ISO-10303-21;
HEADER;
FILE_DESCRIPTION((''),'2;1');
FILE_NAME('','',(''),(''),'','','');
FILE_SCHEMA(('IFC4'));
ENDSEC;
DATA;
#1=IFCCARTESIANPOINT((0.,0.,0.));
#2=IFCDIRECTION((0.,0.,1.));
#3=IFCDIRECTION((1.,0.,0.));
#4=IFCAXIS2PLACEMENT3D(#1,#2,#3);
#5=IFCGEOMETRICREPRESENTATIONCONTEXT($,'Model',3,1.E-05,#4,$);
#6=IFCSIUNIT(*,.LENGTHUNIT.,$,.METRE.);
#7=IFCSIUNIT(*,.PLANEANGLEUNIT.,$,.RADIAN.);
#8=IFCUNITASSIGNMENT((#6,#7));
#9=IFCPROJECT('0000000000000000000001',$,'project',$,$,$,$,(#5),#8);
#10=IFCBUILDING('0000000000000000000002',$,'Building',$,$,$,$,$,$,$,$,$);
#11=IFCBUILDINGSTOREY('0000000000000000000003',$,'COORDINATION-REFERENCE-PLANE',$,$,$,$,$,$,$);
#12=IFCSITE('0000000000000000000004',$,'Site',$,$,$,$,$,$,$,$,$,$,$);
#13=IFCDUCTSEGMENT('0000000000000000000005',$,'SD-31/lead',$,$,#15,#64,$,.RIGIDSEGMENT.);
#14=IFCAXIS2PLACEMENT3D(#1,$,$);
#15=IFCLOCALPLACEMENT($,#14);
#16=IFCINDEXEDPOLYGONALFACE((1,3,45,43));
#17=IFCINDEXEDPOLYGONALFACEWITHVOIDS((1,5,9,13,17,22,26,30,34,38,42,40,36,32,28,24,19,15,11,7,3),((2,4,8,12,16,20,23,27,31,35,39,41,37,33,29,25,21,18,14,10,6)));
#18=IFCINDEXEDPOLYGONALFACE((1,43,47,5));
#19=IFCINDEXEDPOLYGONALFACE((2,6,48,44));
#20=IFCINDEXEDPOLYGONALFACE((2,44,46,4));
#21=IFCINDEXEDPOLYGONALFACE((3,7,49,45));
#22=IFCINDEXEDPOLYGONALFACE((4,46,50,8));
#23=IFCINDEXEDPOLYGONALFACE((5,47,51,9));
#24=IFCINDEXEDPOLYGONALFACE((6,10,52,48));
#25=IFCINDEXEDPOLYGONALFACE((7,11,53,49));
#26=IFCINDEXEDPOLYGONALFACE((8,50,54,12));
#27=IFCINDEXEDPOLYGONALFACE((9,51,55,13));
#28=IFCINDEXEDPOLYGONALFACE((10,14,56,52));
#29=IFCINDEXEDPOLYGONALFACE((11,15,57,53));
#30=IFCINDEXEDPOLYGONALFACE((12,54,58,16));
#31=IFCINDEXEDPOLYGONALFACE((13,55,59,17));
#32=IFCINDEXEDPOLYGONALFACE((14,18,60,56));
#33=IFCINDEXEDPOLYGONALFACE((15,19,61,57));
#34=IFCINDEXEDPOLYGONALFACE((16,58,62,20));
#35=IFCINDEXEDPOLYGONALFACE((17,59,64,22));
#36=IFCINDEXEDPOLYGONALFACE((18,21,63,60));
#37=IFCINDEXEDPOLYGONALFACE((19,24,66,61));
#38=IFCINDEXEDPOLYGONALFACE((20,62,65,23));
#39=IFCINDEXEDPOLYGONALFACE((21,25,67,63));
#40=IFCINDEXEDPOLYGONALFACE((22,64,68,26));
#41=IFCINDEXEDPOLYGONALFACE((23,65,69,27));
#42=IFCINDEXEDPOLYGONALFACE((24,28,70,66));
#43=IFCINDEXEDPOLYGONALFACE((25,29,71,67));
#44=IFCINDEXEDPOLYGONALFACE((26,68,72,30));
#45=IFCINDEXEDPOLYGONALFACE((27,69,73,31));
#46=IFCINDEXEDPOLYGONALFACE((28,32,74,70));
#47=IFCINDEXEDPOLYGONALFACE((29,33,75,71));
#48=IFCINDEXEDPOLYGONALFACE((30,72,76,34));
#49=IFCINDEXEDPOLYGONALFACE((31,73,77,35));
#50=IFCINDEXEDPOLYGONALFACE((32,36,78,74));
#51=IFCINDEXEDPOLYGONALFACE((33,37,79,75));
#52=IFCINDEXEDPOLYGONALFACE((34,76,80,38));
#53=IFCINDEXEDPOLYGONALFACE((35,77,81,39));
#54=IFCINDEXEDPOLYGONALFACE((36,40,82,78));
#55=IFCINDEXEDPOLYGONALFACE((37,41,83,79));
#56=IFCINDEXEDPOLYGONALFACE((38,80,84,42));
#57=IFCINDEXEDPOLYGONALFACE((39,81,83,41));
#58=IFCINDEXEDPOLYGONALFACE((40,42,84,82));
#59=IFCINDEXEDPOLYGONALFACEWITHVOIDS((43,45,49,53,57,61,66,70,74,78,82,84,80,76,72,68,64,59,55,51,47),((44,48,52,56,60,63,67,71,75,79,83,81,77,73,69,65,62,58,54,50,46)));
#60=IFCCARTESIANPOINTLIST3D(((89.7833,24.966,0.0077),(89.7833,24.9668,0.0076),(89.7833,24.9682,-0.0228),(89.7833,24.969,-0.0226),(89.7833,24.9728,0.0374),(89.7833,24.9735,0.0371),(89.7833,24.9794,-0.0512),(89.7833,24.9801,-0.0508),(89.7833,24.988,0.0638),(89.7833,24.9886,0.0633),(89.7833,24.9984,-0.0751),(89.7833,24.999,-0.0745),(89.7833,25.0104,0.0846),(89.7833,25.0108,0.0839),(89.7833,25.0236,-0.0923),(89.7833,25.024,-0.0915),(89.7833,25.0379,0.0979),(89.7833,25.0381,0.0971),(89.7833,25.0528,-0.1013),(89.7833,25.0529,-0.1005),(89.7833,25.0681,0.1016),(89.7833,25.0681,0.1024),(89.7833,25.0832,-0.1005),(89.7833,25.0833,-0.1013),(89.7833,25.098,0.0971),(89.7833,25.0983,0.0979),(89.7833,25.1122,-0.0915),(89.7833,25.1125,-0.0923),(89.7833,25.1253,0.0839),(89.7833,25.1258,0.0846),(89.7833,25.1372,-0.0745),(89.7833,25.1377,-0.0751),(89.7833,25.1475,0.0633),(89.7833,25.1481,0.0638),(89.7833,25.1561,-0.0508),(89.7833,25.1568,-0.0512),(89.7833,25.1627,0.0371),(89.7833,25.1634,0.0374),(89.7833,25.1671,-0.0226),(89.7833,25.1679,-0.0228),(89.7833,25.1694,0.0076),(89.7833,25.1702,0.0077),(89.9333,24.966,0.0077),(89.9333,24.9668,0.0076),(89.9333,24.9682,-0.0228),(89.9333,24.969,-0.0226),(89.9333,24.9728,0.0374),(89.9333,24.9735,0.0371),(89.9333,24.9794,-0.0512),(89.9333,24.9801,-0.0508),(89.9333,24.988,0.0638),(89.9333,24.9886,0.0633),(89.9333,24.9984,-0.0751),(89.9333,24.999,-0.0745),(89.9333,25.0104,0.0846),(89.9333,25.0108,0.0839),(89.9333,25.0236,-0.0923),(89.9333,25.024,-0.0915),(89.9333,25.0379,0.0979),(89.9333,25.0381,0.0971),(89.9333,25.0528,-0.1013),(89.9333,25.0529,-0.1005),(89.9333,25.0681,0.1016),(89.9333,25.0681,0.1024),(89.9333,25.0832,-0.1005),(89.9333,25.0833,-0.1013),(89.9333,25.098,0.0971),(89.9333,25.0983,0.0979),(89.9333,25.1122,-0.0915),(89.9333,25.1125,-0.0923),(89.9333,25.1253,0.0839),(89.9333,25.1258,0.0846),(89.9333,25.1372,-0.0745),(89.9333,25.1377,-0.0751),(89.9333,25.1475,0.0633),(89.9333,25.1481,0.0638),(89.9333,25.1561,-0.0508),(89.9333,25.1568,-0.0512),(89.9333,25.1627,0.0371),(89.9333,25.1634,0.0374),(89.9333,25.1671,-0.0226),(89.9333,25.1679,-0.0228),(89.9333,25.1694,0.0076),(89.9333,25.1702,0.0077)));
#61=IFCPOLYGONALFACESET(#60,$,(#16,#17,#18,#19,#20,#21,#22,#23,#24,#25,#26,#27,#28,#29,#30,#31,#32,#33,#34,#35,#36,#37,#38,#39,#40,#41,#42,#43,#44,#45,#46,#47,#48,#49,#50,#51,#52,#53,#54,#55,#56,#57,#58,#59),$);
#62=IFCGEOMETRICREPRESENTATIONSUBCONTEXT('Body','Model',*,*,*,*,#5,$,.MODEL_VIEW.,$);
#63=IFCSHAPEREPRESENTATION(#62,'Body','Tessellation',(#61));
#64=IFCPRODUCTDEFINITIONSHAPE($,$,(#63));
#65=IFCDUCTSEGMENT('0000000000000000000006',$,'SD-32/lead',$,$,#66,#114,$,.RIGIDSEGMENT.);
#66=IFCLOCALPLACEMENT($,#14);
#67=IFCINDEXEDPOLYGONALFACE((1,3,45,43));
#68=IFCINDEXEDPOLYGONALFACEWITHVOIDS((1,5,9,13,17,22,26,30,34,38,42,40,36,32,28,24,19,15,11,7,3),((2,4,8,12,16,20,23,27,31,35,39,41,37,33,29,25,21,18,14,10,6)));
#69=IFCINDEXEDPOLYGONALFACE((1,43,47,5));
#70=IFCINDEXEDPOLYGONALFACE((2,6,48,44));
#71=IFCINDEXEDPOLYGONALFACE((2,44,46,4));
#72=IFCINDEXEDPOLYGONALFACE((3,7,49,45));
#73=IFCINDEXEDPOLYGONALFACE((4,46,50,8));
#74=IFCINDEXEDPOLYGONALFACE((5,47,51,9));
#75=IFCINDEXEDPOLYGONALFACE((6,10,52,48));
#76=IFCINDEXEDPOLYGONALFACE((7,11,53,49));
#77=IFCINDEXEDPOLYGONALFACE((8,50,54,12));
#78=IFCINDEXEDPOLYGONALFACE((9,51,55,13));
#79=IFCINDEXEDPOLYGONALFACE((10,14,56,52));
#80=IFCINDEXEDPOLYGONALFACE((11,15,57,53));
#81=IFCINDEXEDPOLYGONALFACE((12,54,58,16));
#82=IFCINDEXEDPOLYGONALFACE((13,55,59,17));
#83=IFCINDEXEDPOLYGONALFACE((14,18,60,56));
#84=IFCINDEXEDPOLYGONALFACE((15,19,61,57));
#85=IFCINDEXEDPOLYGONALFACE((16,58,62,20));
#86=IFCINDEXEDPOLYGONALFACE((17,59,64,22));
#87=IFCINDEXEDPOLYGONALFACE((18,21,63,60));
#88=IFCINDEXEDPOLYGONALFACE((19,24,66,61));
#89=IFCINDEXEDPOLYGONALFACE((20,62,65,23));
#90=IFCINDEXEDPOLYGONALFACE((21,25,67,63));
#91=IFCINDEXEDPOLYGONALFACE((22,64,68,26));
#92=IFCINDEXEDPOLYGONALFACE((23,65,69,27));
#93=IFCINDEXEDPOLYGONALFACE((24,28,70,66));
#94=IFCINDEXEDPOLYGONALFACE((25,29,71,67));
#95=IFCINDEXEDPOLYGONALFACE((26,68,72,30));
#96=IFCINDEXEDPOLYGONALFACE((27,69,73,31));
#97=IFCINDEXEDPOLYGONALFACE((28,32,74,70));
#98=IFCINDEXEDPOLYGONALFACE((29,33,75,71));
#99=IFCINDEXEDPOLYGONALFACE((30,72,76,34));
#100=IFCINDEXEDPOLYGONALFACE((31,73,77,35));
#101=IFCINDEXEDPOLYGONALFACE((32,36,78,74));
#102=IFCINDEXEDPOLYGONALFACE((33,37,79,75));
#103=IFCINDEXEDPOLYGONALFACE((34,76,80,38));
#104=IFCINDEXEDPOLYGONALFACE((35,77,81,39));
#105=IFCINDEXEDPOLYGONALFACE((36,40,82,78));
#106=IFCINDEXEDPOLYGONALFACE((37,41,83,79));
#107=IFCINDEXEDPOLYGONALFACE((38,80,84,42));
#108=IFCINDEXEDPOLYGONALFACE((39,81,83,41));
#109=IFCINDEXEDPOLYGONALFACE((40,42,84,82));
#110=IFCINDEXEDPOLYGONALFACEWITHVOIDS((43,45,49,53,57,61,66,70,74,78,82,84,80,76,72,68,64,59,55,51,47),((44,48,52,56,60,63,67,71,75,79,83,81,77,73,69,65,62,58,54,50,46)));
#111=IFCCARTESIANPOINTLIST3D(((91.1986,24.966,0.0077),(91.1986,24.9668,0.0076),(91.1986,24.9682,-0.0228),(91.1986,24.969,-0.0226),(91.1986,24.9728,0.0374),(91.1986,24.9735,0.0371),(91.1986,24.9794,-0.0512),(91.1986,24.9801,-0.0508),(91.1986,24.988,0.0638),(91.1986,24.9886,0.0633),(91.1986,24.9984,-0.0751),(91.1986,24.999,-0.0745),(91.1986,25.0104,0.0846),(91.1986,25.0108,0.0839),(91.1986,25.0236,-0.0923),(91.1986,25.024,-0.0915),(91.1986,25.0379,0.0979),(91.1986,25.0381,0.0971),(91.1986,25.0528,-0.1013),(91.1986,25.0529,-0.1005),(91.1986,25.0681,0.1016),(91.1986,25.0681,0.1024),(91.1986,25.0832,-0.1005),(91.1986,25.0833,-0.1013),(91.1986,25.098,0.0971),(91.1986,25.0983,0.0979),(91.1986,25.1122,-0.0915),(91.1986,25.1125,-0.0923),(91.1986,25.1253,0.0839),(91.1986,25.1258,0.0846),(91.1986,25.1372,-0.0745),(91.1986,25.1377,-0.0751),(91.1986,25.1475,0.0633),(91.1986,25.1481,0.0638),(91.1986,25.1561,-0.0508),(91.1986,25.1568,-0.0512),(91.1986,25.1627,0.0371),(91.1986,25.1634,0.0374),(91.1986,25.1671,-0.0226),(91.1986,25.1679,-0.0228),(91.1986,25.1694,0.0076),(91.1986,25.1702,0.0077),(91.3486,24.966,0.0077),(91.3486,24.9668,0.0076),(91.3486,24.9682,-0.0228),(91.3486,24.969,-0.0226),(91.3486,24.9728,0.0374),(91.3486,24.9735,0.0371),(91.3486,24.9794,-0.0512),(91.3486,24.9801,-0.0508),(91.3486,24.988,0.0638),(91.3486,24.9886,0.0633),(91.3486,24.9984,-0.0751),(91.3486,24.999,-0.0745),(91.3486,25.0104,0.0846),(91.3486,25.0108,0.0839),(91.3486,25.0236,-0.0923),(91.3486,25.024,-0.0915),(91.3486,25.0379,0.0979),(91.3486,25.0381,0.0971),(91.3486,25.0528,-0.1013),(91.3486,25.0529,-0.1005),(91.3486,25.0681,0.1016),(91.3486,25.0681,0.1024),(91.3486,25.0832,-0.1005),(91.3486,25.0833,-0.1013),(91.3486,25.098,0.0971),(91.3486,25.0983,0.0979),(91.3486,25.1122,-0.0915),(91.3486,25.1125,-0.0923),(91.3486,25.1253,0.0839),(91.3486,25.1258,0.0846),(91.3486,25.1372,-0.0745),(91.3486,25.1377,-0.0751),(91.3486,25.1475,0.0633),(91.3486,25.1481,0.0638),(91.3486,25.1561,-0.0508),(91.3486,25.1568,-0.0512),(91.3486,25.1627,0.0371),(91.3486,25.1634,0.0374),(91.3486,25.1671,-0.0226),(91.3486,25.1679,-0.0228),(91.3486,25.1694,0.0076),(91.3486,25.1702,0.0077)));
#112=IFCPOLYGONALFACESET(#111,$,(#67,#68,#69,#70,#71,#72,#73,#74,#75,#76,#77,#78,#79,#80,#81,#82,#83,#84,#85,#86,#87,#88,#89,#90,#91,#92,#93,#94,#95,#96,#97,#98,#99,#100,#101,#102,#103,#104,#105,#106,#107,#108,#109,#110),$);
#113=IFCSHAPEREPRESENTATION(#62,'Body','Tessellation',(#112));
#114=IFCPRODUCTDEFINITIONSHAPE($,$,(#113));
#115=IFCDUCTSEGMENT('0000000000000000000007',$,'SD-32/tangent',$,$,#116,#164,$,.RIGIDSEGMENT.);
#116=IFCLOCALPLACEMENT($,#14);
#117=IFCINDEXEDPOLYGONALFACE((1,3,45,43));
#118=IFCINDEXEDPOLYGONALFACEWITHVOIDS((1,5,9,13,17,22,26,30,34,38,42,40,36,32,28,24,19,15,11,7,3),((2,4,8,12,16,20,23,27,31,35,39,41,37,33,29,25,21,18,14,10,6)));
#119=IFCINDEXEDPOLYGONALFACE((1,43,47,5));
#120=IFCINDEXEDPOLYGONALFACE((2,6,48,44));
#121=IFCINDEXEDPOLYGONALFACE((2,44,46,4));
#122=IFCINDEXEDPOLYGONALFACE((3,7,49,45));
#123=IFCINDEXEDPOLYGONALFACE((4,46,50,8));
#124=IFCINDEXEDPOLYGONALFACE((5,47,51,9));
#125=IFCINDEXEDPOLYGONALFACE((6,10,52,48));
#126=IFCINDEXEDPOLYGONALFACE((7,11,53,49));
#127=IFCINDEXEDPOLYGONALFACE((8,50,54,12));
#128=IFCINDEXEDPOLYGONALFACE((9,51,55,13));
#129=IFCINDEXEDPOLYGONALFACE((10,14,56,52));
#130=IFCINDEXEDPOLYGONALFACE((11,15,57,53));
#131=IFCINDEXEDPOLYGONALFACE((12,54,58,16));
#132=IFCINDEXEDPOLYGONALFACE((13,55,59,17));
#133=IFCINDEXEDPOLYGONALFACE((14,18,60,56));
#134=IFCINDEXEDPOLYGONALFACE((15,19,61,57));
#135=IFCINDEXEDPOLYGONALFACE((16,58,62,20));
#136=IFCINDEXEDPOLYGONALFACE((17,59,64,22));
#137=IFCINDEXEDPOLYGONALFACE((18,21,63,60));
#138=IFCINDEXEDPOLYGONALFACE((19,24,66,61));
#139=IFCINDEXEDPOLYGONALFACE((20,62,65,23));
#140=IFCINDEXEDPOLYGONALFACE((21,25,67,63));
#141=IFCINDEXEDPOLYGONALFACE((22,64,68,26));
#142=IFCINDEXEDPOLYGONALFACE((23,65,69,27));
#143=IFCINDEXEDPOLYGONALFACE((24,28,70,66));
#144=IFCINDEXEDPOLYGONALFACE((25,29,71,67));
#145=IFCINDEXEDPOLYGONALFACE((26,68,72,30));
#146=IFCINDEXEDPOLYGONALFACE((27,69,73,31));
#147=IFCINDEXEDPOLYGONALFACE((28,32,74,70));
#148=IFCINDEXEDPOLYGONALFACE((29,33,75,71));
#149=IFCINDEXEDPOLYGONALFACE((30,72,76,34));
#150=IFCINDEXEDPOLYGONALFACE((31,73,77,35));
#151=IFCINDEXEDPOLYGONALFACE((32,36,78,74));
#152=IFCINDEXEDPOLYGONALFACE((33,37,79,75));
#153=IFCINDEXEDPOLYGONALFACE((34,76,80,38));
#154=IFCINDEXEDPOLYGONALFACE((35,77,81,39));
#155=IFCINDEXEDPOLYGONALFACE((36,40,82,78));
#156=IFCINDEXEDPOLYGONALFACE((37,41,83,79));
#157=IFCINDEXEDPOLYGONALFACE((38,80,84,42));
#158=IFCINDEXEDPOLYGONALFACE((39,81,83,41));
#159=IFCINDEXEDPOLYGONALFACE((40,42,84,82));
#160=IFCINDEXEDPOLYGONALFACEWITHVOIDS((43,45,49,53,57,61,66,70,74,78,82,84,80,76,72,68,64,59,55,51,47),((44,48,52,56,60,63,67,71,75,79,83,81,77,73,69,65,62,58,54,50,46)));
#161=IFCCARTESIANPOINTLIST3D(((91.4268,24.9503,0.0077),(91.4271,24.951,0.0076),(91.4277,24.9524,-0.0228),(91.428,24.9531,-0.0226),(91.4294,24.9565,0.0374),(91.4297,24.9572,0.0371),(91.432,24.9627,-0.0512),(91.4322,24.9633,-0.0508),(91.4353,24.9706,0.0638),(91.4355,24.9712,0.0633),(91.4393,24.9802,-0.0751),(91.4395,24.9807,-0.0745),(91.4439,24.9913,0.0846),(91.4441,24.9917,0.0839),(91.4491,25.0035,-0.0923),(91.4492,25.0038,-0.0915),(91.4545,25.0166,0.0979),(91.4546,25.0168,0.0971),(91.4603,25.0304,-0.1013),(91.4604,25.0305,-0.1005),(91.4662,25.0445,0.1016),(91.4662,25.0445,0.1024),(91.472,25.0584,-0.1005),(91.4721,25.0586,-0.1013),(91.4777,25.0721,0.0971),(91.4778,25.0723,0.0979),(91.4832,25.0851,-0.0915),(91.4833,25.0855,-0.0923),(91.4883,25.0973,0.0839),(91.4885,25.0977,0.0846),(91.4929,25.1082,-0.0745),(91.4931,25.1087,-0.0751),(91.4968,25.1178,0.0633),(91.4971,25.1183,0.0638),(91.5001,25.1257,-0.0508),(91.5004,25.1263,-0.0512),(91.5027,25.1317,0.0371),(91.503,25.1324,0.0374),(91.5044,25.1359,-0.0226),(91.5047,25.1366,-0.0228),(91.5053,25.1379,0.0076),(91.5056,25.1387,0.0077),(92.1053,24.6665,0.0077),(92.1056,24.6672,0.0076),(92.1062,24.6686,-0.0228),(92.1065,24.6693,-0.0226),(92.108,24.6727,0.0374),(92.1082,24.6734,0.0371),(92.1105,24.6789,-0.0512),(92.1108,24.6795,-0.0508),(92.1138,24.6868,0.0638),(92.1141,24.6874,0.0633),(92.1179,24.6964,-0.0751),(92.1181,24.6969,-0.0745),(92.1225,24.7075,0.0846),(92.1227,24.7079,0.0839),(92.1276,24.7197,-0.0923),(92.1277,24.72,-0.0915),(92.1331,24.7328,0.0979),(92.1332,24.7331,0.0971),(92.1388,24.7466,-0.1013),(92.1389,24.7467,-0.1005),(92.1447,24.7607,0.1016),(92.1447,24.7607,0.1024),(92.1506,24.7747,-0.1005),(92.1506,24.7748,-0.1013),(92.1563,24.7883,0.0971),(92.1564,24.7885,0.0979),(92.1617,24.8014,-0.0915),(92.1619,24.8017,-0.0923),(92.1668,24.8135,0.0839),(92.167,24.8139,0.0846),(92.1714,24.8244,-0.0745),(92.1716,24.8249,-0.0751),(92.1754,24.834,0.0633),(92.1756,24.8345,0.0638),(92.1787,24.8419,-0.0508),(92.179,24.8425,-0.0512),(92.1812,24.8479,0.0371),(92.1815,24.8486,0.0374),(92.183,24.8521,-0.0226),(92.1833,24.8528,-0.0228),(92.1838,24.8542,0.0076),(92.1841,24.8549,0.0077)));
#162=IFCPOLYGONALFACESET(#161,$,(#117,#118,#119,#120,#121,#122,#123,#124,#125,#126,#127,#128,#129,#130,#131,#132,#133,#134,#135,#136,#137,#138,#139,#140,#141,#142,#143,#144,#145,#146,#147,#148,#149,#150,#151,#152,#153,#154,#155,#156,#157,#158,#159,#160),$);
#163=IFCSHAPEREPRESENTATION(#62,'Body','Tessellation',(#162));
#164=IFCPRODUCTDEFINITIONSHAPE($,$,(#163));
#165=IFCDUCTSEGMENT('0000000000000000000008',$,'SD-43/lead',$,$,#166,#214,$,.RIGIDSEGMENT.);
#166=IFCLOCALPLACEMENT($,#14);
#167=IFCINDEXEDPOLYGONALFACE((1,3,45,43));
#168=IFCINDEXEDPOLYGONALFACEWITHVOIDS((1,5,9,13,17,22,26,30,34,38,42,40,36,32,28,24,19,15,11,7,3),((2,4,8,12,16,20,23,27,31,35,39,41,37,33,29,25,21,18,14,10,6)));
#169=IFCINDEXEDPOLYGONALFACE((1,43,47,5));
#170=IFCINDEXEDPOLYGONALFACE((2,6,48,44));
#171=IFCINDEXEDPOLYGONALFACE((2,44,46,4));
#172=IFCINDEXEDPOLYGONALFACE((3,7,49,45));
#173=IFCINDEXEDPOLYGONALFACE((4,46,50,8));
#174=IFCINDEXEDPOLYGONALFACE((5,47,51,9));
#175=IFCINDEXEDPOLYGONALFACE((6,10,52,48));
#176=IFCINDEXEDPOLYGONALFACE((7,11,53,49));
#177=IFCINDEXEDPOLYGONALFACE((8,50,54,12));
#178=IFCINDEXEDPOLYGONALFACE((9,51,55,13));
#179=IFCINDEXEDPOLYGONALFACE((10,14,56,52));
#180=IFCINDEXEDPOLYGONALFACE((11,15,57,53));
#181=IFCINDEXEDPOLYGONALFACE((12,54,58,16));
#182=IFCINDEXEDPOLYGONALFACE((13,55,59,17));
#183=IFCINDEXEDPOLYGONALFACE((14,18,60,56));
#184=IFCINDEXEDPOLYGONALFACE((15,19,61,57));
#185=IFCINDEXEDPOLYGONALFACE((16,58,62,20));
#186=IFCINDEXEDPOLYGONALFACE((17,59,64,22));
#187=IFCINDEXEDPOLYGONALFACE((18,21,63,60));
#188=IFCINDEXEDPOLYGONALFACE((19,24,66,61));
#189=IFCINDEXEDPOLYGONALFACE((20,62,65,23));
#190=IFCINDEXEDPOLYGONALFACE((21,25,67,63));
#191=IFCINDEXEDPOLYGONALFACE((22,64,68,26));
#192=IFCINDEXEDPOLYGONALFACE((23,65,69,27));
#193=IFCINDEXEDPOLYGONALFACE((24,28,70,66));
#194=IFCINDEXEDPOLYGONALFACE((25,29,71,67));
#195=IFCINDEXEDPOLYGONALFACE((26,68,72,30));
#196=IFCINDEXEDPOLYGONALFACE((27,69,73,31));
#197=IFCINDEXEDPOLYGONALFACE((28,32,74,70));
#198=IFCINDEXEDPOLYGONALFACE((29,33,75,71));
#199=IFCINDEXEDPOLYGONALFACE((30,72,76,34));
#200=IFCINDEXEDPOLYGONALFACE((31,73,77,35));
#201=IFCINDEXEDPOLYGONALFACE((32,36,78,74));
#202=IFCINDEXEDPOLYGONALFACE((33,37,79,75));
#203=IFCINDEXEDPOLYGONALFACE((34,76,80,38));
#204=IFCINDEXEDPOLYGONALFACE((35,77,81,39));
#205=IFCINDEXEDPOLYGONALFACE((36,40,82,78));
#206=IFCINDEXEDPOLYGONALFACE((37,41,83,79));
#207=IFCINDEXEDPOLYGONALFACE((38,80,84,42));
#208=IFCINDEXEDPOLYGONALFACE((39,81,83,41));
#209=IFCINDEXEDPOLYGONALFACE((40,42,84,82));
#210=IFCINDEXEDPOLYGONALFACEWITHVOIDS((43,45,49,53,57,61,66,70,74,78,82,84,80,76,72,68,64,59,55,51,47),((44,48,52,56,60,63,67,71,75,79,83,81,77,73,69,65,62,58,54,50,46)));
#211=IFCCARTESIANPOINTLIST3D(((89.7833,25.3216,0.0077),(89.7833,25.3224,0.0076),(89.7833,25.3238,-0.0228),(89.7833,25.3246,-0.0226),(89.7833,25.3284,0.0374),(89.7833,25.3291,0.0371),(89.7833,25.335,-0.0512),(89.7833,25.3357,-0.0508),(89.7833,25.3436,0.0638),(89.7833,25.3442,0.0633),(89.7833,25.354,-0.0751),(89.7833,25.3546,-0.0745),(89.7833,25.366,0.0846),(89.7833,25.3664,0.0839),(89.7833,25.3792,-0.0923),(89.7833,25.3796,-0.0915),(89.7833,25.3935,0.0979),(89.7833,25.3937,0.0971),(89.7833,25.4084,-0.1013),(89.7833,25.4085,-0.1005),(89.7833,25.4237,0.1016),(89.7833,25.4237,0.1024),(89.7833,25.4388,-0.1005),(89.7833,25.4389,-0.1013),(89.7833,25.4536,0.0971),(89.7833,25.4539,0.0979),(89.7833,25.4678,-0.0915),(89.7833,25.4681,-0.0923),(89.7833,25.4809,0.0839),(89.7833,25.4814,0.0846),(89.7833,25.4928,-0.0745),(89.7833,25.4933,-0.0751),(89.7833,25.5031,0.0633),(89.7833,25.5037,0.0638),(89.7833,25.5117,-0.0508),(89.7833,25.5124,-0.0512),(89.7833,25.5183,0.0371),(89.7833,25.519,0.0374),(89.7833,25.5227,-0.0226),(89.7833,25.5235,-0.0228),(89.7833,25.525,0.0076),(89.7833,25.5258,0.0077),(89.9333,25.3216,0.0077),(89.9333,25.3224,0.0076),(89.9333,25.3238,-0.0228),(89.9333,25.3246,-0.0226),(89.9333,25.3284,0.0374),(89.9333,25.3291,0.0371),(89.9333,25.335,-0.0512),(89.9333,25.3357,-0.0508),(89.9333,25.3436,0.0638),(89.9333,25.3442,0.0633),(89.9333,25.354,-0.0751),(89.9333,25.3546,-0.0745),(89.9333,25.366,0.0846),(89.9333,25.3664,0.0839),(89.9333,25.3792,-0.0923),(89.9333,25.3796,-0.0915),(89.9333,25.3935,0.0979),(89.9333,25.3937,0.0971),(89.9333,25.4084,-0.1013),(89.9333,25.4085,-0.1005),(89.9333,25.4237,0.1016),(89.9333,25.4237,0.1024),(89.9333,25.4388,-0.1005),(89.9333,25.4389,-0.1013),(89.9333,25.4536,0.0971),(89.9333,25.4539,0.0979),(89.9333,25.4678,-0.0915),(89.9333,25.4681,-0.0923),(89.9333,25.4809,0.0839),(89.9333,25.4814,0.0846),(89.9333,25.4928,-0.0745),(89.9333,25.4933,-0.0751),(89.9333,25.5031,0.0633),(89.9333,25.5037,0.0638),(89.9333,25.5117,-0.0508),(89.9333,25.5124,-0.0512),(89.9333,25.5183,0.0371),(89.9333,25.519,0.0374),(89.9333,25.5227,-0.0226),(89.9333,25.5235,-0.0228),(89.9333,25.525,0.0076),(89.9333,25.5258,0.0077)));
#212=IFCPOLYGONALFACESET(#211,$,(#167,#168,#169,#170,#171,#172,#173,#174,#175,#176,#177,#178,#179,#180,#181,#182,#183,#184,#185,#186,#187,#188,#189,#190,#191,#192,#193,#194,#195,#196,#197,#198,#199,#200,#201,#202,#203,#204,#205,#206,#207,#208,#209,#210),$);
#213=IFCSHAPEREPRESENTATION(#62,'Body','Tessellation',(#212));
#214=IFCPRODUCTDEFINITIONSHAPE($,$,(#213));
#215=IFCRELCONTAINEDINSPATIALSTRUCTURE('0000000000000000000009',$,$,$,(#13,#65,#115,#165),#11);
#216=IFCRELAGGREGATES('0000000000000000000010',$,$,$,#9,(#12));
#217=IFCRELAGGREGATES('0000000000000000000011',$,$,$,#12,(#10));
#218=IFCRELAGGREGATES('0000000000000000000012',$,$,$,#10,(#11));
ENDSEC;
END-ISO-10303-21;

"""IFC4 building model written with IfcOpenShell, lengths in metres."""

from ifc_helpers import new_model, si_unit, frame, origin_with_axes, place, context, subcontext, project, spatial, hollow_circle, extrude, element, save


model = new_model("IFC4")

# Units and contexts
model_context = context("Model", 3, precision=1e-05, world=origin_with_axes())
body_context_1 = subcontext(model_context, "Body", "Model", "MODEL_VIEW")
ifc_project = project(units=[si_unit("LENGTHUNIT", "METRE"), si_unit("PLANEANGLEUNIT", "RADIAN")], contexts=[model_context])

# Site, building, storey
site = spatial("IfcSite", under=ifc_project, Name="Site")
building = spatial("IfcBuilding", under=site, Name="Building")
storey = spatial("IfcBuildingStorey", under=building, Name="COORDINATION-REFERENCE-PLANE")

# Duct segments
for number, where, z_axis, x_axis, name in (
    (1, (89.9333, 25.0681, 0.0), (-1.0, 0.0, 0.0), (0.0, 0.0, 1.0), "SD-31/lead"),
    (2, (91.1986, 25.0681, 0.0), (1.0, 0.0, 0.0), (0.0, 0.0, 1.0), "SD-32/lead"),
):
    element("IfcDuctSegment", number, at=place(None, frame(where, z_axis=z_axis, x_axis=x_axis)), inside=storey, Name=name, PredefinedType="RIGIDSEGMENT", context=body_context_1, shape_type="SweptSolid", body=[
        extrude(hollow_circle(Radius=0.1024, WallThickness=0.0008), origin_with_axes(), (0.0, 0.0, 1.0), 0.15),
    ])

# Duct segment
duct_segment_1_placement = place(None, frame((91.4662, 25.0445, 0.0), z_axis=(0.922564, -0.385845, 0.0), x_axis=(0.0, 0.0, 1.0)))
element("IfcDuctSegment", 3, at=duct_segment_1_placement, inside=storey, Name="SD-32/tangent", PredefinedType="RIGIDSEGMENT", context=body_context_1, shape_type="SweptSolid", body=[
    extrude(hollow_circle(Radius=0.1024, WallThickness=0.0008), origin_with_axes(), (0.0, 0.0, 1.0), 0.7355),
])

# Duct segment
for number, where, z_axis, x_axis, name in (
    (4, (89.9333, 25.4237, 0.0), (-1.0, 0.0, 0.0), (0.0, 0.0, 1.0), "SD-43/lead"),
):
    element("IfcDuctSegment", number, at=place(None, frame(where, z_axis=z_axis, x_axis=x_axis)), inside=storey, Name=name, PredefinedType="RIGIDSEGMENT", context=body_context_1, shape_type="SweptSolid", body=[
        extrude(hollow_circle(Radius=0.1024, WallThickness=0.0008), origin_with_axes(), (0.0, 0.0, 1.0), 0.15),
    ])

save(model, "model.ifc")
